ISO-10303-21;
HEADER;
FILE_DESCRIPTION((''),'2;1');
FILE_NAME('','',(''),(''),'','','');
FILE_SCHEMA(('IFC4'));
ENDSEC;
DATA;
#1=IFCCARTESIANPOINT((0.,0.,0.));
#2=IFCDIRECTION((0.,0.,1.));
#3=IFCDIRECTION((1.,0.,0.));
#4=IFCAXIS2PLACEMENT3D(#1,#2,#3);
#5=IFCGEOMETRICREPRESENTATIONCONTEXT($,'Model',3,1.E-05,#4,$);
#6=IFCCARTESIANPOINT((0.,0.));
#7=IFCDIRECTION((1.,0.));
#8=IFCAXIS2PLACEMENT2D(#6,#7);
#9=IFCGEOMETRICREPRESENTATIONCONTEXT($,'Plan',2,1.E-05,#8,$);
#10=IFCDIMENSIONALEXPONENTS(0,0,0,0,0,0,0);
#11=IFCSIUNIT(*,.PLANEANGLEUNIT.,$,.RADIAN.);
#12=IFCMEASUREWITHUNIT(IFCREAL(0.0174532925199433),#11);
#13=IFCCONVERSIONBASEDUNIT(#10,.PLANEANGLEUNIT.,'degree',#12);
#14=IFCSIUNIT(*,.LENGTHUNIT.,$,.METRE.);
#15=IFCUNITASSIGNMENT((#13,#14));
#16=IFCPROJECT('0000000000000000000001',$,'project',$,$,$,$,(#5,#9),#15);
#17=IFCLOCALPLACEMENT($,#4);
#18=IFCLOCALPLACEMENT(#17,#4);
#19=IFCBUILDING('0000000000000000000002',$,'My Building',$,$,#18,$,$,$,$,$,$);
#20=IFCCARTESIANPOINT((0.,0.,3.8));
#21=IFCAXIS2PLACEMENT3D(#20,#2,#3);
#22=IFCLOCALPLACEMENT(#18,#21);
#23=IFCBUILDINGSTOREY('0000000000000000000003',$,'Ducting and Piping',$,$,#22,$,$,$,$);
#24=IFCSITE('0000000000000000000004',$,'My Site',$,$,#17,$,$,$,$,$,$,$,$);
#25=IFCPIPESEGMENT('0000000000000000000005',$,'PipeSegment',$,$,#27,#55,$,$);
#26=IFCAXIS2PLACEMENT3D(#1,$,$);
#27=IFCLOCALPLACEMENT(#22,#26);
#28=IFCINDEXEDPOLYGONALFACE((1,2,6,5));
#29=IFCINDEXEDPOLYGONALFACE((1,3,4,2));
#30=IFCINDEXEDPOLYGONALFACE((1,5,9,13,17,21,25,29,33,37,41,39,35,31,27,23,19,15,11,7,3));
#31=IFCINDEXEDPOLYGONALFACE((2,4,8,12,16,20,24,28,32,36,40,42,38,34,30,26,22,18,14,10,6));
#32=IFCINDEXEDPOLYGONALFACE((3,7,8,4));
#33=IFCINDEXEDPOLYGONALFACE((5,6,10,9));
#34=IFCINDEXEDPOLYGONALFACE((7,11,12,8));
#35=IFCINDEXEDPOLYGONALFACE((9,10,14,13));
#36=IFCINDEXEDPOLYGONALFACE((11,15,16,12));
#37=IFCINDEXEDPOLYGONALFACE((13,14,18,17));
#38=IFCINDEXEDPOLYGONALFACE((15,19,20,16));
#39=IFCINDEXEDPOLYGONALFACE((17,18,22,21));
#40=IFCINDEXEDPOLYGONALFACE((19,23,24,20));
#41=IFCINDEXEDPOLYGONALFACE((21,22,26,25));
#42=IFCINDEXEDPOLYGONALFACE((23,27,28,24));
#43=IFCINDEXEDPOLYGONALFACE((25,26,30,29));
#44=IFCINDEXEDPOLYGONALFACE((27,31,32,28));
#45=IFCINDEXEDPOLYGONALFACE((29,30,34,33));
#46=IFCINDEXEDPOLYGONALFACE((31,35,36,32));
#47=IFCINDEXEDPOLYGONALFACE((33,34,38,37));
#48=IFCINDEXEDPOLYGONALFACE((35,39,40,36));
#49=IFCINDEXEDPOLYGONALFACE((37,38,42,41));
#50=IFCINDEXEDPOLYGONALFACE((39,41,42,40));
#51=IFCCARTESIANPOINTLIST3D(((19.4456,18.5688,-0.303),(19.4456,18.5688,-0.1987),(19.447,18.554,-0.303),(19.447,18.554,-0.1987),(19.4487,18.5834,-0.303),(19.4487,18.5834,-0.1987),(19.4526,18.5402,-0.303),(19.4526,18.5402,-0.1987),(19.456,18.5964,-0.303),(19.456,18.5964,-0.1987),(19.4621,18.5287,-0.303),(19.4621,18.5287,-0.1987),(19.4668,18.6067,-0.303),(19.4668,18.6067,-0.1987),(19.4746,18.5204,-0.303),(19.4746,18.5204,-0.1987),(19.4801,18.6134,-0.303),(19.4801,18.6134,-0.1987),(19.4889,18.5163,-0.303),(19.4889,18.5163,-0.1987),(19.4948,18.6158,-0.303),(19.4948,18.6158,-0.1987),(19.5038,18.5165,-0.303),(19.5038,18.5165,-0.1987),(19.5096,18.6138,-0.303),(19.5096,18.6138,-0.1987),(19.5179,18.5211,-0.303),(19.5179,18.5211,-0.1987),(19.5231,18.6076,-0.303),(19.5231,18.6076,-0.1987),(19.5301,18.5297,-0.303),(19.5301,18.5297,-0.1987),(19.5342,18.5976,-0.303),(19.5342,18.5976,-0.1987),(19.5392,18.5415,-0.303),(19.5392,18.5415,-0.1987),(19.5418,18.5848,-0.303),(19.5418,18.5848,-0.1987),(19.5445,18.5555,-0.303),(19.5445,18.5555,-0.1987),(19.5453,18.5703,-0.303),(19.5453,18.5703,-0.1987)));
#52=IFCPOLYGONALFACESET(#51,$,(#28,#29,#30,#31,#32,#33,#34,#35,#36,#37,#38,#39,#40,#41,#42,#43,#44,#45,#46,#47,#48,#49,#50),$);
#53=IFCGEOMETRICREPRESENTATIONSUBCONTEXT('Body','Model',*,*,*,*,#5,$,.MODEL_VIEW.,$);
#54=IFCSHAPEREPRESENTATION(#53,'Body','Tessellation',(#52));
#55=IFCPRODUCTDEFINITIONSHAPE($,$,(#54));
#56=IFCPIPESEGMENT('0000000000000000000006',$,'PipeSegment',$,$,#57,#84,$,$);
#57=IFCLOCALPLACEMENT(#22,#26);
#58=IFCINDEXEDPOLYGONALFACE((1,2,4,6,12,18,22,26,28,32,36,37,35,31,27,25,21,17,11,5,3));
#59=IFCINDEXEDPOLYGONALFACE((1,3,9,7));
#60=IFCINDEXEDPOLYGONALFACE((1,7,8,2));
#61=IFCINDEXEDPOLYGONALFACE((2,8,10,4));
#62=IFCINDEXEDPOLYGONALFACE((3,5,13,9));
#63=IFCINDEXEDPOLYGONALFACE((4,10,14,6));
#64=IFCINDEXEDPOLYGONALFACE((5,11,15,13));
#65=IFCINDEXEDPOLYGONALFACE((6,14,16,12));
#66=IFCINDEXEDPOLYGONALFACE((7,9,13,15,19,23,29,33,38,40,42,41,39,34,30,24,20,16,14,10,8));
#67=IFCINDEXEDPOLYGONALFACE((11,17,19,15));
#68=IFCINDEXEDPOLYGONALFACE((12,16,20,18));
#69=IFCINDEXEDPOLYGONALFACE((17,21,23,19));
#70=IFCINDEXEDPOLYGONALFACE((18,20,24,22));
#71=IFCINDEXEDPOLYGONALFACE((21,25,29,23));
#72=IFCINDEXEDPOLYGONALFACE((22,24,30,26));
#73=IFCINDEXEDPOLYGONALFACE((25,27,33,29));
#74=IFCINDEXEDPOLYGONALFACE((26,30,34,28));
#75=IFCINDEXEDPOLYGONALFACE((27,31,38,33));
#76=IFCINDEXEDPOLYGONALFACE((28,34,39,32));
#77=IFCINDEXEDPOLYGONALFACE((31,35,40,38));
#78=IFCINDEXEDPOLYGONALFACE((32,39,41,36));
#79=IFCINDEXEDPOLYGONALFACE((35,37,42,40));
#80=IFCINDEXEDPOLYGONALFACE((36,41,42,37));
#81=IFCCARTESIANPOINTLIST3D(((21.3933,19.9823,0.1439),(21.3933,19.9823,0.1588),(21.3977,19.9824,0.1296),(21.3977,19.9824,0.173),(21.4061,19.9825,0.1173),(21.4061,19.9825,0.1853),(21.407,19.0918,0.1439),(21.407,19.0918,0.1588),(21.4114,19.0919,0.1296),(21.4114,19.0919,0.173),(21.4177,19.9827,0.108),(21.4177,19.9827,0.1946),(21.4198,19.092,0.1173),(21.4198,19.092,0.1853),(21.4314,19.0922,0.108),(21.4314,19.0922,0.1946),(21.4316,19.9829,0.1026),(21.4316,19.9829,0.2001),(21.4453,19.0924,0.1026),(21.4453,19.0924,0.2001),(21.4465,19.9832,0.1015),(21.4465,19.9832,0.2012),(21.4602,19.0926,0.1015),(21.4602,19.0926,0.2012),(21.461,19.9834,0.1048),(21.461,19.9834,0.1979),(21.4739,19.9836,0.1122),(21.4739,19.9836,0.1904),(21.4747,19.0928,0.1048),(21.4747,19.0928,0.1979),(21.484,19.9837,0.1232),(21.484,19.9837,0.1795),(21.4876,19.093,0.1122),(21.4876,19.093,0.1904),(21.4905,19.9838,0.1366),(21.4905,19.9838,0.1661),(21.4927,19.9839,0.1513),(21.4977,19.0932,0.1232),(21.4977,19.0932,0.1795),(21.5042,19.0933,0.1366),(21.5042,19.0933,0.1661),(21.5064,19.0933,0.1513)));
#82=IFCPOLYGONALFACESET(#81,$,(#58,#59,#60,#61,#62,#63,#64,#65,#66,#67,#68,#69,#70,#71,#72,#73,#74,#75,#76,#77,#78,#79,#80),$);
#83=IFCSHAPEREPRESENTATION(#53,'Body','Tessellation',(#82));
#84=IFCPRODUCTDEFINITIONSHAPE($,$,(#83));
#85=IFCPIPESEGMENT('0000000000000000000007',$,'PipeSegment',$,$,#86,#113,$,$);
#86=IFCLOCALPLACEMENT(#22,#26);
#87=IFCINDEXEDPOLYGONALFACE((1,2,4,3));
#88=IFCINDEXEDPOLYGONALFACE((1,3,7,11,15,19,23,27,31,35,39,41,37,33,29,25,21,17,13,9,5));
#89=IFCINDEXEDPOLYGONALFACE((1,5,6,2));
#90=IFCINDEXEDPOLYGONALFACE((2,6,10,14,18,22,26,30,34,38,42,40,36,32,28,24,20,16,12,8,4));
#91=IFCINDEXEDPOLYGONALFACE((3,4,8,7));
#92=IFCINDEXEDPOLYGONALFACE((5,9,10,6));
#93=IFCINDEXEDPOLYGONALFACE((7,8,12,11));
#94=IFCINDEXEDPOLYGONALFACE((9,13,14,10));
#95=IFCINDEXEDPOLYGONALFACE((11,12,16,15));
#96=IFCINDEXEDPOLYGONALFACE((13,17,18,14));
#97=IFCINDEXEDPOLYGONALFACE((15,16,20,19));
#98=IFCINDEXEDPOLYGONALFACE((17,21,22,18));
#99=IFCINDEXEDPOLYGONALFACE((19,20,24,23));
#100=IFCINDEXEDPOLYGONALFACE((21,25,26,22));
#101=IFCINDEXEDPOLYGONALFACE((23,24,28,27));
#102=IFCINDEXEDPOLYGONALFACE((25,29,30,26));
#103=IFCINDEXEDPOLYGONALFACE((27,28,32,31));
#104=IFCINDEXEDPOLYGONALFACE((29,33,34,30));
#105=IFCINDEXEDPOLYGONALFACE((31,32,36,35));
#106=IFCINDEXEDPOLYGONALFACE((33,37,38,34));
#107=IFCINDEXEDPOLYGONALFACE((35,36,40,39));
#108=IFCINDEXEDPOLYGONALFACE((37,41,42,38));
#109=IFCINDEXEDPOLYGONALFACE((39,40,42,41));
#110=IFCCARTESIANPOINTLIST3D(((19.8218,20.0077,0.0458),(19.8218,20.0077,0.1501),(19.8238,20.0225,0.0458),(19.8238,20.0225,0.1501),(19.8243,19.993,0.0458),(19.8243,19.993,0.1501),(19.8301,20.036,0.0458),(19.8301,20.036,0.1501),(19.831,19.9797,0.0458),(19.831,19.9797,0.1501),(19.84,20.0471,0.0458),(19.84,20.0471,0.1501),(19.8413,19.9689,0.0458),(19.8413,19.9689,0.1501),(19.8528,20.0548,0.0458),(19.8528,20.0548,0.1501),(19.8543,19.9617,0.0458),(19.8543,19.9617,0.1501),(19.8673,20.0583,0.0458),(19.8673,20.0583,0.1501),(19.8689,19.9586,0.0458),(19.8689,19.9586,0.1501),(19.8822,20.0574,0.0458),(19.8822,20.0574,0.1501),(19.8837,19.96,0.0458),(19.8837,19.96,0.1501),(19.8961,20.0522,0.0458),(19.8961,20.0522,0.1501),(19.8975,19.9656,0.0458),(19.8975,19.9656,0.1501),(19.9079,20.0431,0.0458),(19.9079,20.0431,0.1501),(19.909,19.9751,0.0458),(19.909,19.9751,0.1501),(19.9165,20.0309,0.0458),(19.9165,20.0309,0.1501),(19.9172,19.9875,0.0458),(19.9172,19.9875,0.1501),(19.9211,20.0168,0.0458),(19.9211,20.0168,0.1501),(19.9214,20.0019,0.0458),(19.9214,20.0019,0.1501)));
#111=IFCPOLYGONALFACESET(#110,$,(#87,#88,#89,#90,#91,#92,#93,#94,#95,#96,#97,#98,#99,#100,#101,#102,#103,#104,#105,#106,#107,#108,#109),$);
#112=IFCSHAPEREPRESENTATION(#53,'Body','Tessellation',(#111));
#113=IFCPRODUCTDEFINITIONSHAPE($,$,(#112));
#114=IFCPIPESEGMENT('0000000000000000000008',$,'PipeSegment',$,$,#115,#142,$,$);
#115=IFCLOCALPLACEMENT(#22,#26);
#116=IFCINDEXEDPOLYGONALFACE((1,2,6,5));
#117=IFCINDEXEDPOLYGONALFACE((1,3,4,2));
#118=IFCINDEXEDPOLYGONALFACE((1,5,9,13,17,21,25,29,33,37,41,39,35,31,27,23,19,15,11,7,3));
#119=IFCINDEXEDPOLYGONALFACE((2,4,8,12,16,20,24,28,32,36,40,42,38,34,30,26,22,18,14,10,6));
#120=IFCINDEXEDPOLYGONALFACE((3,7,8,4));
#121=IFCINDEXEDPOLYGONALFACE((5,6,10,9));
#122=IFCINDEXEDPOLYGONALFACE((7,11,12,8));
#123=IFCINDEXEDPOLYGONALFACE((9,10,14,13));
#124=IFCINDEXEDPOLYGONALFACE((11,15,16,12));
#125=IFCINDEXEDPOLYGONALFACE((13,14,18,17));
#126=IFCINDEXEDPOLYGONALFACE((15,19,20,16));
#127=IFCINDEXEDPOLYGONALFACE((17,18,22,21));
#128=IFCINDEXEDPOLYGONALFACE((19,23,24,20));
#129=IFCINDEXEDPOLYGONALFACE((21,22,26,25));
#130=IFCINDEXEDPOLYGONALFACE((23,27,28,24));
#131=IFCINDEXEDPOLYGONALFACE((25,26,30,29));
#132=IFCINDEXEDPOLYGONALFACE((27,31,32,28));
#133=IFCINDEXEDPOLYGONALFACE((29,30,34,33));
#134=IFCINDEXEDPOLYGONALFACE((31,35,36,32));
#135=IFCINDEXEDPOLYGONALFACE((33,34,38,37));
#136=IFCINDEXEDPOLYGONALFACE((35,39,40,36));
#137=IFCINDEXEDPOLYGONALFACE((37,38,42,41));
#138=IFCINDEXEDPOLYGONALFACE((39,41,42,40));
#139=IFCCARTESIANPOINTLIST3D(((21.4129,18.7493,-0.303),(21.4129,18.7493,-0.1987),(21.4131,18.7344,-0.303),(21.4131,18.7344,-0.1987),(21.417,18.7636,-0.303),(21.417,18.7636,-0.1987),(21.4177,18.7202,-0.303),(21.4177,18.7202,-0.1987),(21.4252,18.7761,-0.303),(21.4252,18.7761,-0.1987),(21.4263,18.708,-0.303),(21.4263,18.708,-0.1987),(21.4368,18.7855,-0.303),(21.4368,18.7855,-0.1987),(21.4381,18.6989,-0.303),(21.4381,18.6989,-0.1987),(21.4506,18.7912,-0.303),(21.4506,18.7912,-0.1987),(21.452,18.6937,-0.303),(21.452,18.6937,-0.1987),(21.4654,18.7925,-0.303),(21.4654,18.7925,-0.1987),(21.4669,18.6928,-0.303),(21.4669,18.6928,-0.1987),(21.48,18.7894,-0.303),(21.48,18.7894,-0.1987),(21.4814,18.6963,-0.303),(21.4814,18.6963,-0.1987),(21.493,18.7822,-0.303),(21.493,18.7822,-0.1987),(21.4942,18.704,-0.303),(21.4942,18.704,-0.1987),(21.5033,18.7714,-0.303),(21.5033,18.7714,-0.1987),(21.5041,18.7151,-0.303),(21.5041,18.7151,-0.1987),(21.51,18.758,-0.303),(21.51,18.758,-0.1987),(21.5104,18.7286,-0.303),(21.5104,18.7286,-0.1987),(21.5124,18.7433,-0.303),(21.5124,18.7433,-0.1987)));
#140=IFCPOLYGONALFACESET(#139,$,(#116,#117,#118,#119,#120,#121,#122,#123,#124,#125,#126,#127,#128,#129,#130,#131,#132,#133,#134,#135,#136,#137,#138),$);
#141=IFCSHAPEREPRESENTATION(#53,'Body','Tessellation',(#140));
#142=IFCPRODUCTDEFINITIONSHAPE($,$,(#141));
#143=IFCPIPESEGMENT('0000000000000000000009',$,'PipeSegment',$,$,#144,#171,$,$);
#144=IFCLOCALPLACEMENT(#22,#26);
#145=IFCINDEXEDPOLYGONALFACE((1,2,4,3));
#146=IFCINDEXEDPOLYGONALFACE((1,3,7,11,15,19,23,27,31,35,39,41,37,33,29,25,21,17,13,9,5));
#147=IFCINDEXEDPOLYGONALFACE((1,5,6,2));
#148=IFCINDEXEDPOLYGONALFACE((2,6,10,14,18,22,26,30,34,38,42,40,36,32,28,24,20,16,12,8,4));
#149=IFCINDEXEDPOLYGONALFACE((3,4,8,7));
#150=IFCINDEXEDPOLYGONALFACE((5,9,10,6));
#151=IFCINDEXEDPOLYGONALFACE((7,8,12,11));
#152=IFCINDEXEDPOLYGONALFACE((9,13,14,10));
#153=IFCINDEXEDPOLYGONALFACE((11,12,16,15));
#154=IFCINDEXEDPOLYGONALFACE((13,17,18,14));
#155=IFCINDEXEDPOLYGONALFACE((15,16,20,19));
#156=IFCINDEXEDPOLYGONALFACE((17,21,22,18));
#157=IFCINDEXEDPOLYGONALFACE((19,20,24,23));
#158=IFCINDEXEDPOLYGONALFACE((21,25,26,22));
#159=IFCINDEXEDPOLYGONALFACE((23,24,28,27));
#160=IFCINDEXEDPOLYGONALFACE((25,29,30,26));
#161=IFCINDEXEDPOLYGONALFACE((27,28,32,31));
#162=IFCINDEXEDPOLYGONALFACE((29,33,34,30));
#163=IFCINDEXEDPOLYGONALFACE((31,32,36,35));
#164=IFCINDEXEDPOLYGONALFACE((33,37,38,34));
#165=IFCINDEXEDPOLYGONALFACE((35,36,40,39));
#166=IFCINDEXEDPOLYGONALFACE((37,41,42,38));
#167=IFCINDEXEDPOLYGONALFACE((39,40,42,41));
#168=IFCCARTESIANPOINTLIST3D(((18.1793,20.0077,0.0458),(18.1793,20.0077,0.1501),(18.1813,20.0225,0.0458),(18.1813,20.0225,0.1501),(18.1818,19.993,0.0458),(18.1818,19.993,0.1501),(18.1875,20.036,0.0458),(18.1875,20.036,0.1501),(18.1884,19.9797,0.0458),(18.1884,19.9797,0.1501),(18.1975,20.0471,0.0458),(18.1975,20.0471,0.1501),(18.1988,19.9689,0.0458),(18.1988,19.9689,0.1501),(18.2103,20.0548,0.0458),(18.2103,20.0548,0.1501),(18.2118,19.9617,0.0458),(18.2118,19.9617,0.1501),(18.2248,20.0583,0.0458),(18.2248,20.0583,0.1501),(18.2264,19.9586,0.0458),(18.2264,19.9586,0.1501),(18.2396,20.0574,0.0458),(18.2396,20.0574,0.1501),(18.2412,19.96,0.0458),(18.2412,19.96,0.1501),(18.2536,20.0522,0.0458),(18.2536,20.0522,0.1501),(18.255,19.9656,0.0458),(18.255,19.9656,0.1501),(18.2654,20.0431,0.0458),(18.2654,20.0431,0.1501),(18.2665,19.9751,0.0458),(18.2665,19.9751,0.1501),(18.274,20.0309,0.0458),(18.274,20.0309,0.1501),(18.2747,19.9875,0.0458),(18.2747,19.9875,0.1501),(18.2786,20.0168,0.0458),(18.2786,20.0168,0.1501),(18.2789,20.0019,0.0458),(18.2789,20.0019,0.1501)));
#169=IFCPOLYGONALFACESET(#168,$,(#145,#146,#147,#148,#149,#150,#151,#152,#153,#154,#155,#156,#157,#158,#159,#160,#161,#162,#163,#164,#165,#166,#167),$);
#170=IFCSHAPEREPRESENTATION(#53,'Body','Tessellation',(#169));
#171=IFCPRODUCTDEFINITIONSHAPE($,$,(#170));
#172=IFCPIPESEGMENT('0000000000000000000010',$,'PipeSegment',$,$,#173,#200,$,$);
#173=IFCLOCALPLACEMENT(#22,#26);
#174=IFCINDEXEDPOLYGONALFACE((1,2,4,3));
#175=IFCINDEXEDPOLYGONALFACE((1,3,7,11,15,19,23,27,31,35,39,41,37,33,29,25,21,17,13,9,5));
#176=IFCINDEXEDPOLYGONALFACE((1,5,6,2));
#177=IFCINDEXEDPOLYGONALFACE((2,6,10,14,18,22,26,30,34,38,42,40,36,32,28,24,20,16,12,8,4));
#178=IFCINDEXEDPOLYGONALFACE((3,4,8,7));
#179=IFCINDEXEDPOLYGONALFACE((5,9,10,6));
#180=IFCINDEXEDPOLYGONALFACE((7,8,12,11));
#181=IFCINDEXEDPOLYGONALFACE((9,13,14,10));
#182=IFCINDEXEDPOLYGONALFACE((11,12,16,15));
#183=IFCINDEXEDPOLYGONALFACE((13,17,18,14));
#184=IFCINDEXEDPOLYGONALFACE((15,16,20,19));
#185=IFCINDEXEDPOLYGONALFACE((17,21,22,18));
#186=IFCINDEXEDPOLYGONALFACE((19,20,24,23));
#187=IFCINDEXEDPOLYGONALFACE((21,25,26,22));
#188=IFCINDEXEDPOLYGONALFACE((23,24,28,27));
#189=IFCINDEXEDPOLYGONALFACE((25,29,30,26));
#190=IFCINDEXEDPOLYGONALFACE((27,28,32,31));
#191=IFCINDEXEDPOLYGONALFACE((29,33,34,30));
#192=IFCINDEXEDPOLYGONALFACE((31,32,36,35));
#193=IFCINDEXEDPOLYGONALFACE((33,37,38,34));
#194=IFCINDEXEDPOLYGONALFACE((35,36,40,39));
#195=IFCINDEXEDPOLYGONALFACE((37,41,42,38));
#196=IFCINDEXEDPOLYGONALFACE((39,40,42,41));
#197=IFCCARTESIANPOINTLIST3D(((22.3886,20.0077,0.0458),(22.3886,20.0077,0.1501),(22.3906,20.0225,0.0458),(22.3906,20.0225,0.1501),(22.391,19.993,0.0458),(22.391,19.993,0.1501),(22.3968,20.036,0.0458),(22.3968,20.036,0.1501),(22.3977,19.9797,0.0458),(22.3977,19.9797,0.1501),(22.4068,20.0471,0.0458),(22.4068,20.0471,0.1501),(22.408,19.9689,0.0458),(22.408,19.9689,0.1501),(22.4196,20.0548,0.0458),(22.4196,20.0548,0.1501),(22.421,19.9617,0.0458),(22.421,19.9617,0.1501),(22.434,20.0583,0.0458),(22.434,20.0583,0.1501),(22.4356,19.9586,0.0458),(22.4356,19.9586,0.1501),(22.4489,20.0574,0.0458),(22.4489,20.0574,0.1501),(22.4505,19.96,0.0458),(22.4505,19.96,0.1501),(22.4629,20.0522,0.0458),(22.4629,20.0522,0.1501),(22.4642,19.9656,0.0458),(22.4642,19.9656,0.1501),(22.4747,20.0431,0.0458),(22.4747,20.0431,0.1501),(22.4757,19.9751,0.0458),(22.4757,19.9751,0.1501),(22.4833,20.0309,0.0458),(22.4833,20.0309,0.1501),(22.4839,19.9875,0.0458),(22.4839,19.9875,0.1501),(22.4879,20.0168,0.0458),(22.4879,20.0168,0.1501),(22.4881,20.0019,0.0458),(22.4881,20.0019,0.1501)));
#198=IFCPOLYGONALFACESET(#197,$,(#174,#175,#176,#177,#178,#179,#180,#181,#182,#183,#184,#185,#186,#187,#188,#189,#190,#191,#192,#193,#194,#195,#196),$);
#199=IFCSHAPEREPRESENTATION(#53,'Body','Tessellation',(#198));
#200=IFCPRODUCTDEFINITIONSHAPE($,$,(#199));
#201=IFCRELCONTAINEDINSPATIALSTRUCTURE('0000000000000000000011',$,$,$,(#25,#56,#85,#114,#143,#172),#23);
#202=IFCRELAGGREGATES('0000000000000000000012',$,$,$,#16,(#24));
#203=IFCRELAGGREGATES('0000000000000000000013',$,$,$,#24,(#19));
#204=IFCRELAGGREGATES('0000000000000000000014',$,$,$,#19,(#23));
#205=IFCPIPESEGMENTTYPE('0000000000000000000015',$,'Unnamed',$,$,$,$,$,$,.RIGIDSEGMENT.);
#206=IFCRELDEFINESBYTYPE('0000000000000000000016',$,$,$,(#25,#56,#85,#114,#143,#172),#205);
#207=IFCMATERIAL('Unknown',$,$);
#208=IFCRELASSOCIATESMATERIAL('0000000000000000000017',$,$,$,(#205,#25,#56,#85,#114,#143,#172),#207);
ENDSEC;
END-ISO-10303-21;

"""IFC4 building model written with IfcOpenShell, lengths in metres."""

from ifc_helpers import new_model, entity, si_unit, converted_unit, frame, origin_with_axes, origin_2d_with_axis, place, context, subcontext, project, spatial, circle, extrude, material, material_profile, profile_set, profile_usage, type_object, element, save


model = new_model("IFC4")

# Units and contexts
model_context = context("Model", 3, precision=1e-05, world=origin_with_axes())
plan_context = context("Plan", 2, precision=1e-05, world=origin_2d_with_axis())
body_context = subcontext(model_context, "Body", "Model", "MODEL_VIEW")
ifc_project = project(units=[converted_unit("PLANEANGLEUNIT", "degree", entity("IfcReal", 0.0174532925199433), si_unit("PLANEANGLEUNIT", "RADIAN"), dimensions=[0, 0, 0, 0, 0, 0, 0]), si_unit("LENGTHUNIT", "METRE")], contexts=[model_context, plan_context])

# Site, building, storey
site_placement = place(None, origin_with_axes())
site = spatial("IfcSite", under=ifc_project, at=site_placement, Name="My Site")
building_placement = place(site_placement, origin_with_axes())
building = spatial("IfcBuilding", under=site, at=building_placement, Name="My Building")
storey_placement = place(building_placement, frame((0.0, 0.0, 3.8), z_axis=(0.0, 0.0, 1.0), x_axis=(1.0, 0.0, 0.0)))
storey = spatial("IfcBuildingStorey", under=building, at=storey_placement, Name="Ducting and Piping")

# Pipe segments
ifc_material = material(Name="Unknown")
ifc_material_profile_1 = material_profile(ifc_material, circle(Radius=0.05))
ifc_profile_set_1 = profile_set([ifc_material_profile_1])
pipe_segment_type = type_object("IfcPipeSegmentType", Name="Unnamed", PredefinedType="RIGIDSEGMENT", material=ifc_profile_set_1)
ifc_profile_usage_1 = profile_usage(ifc_profile_set_1, cardinal=5)
pipe_segment_1_placement = place(storey_placement, frame((19.4956, 18.5658, -0.303), z_axis=(0.0, 0.0, 1.0), x_axis=(-0.015371, 0.999882, 0.0)))
element("IfcPipeSegment", 1, at=pipe_segment_1_placement, inside=storey, type_object=pipe_segment_type, material=ifc_profile_usage_1, Name="PipeSegment", context=body_context, shape_type="SweptSolid", body=[
    extrude(circle(Radius=0.05), origin_with_axes(), (0.0, 0.0, 1.0), 0.1043),
])
ifc_profile_usage_2 = profile_usage(ifc_profile_set_1, cardinal=5)
pipe_segment_2_placement = place(storey_placement, frame((21.4427, 19.9831, 0.1513), z_axis=(0.015385, -0.999882, 0.0), x_axis=(0.999882, 0.015385, 0.0)))
element("IfcPipeSegment", 2, at=pipe_segment_2_placement, inside=storey, type_object=pipe_segment_type, material=ifc_profile_usage_2, Name="PipeSegment", context=body_context, shape_type="SweptSolid", body=[
    extrude(circle(Radius=0.05), origin_with_axes(), (0.0, 0.0, 1.0), 0.8907),
])
ifc_profile_usage_3 = profile_usage(ifc_profile_set_1, cardinal=5)
pipe_segment_3_placement = place(storey_placement, frame((19.8718, 20.0085, 0.0458), z_axis=(0.0, 0.0, 1.0), x_axis=(-0.999873, -0.015924, 0.0)))
element("IfcPipeSegment", 3, at=pipe_segment_3_placement, inside=storey, type_object=pipe_segment_type, material=ifc_profile_usage_3, Name="PipeSegment", context=body_context, shape_type="SweptSolid", body=[
    extrude(circle(Radius=0.05), origin_with_axes(), (0.0, 0.0, 1.0), 0.1043),
])
ifc_profile_usage_4 = profile_usage(ifc_profile_set_1, cardinal=5)
pipe_segment_4_placement = place(storey_placement, frame((21.4624, 18.7426, -0.303), z_axis=(0.0, 0.0, 1.0), x_axis=(0.999889, 0.014879, 0.0)))
element("IfcPipeSegment", 4, at=pipe_segment_4_placement, inside=storey, type_object=pipe_segment_type, material=ifc_profile_usage_4, Name="PipeSegment", context=body_context, shape_type="SweptSolid", body=[
    extrude(circle(Radius=0.05), origin_with_axes(), (0.0, 0.0, 1.0), 0.1043),
])
ifc_profile_usage_5 = profile_usage(ifc_profile_set_1, cardinal=5)
pipe_segment_5_placement = place(storey_placement, frame((18.2293, 20.0085, 0.0458), z_axis=(0.0, 0.0, 1.0), x_axis=(-0.999873, -0.015924, 0.0)))
element("IfcPipeSegment", 5, at=pipe_segment_5_placement, inside=storey, type_object=pipe_segment_type, material=ifc_profile_usage_5, Name="PipeSegment", context=body_context, shape_type="SweptSolid", body=[
    extrude(circle(Radius=0.05), origin_with_axes(), (0.0, 0.0, 1.0), 0.1043),
])
ifc_profile_usage_6 = profile_usage(ifc_profile_set_1, cardinal=5)
pipe_segment_6_placement = place(storey_placement, frame((22.4386, 20.0085, 0.0458), z_axis=(0.0, 0.0, 1.0), x_axis=(-0.999873, -0.015924, 0.0)))
element("IfcPipeSegment", 6, at=pipe_segment_6_placement, inside=storey, type_object=pipe_segment_type, material=ifc_profile_usage_6, Name="PipeSegment", context=body_context, shape_type="SweptSolid", body=[
    extrude(circle(Radius=0.05), origin_with_axes(), (0.0, 0.0, 1.0), 0.1043),
])

save(model, "model.ifc")
